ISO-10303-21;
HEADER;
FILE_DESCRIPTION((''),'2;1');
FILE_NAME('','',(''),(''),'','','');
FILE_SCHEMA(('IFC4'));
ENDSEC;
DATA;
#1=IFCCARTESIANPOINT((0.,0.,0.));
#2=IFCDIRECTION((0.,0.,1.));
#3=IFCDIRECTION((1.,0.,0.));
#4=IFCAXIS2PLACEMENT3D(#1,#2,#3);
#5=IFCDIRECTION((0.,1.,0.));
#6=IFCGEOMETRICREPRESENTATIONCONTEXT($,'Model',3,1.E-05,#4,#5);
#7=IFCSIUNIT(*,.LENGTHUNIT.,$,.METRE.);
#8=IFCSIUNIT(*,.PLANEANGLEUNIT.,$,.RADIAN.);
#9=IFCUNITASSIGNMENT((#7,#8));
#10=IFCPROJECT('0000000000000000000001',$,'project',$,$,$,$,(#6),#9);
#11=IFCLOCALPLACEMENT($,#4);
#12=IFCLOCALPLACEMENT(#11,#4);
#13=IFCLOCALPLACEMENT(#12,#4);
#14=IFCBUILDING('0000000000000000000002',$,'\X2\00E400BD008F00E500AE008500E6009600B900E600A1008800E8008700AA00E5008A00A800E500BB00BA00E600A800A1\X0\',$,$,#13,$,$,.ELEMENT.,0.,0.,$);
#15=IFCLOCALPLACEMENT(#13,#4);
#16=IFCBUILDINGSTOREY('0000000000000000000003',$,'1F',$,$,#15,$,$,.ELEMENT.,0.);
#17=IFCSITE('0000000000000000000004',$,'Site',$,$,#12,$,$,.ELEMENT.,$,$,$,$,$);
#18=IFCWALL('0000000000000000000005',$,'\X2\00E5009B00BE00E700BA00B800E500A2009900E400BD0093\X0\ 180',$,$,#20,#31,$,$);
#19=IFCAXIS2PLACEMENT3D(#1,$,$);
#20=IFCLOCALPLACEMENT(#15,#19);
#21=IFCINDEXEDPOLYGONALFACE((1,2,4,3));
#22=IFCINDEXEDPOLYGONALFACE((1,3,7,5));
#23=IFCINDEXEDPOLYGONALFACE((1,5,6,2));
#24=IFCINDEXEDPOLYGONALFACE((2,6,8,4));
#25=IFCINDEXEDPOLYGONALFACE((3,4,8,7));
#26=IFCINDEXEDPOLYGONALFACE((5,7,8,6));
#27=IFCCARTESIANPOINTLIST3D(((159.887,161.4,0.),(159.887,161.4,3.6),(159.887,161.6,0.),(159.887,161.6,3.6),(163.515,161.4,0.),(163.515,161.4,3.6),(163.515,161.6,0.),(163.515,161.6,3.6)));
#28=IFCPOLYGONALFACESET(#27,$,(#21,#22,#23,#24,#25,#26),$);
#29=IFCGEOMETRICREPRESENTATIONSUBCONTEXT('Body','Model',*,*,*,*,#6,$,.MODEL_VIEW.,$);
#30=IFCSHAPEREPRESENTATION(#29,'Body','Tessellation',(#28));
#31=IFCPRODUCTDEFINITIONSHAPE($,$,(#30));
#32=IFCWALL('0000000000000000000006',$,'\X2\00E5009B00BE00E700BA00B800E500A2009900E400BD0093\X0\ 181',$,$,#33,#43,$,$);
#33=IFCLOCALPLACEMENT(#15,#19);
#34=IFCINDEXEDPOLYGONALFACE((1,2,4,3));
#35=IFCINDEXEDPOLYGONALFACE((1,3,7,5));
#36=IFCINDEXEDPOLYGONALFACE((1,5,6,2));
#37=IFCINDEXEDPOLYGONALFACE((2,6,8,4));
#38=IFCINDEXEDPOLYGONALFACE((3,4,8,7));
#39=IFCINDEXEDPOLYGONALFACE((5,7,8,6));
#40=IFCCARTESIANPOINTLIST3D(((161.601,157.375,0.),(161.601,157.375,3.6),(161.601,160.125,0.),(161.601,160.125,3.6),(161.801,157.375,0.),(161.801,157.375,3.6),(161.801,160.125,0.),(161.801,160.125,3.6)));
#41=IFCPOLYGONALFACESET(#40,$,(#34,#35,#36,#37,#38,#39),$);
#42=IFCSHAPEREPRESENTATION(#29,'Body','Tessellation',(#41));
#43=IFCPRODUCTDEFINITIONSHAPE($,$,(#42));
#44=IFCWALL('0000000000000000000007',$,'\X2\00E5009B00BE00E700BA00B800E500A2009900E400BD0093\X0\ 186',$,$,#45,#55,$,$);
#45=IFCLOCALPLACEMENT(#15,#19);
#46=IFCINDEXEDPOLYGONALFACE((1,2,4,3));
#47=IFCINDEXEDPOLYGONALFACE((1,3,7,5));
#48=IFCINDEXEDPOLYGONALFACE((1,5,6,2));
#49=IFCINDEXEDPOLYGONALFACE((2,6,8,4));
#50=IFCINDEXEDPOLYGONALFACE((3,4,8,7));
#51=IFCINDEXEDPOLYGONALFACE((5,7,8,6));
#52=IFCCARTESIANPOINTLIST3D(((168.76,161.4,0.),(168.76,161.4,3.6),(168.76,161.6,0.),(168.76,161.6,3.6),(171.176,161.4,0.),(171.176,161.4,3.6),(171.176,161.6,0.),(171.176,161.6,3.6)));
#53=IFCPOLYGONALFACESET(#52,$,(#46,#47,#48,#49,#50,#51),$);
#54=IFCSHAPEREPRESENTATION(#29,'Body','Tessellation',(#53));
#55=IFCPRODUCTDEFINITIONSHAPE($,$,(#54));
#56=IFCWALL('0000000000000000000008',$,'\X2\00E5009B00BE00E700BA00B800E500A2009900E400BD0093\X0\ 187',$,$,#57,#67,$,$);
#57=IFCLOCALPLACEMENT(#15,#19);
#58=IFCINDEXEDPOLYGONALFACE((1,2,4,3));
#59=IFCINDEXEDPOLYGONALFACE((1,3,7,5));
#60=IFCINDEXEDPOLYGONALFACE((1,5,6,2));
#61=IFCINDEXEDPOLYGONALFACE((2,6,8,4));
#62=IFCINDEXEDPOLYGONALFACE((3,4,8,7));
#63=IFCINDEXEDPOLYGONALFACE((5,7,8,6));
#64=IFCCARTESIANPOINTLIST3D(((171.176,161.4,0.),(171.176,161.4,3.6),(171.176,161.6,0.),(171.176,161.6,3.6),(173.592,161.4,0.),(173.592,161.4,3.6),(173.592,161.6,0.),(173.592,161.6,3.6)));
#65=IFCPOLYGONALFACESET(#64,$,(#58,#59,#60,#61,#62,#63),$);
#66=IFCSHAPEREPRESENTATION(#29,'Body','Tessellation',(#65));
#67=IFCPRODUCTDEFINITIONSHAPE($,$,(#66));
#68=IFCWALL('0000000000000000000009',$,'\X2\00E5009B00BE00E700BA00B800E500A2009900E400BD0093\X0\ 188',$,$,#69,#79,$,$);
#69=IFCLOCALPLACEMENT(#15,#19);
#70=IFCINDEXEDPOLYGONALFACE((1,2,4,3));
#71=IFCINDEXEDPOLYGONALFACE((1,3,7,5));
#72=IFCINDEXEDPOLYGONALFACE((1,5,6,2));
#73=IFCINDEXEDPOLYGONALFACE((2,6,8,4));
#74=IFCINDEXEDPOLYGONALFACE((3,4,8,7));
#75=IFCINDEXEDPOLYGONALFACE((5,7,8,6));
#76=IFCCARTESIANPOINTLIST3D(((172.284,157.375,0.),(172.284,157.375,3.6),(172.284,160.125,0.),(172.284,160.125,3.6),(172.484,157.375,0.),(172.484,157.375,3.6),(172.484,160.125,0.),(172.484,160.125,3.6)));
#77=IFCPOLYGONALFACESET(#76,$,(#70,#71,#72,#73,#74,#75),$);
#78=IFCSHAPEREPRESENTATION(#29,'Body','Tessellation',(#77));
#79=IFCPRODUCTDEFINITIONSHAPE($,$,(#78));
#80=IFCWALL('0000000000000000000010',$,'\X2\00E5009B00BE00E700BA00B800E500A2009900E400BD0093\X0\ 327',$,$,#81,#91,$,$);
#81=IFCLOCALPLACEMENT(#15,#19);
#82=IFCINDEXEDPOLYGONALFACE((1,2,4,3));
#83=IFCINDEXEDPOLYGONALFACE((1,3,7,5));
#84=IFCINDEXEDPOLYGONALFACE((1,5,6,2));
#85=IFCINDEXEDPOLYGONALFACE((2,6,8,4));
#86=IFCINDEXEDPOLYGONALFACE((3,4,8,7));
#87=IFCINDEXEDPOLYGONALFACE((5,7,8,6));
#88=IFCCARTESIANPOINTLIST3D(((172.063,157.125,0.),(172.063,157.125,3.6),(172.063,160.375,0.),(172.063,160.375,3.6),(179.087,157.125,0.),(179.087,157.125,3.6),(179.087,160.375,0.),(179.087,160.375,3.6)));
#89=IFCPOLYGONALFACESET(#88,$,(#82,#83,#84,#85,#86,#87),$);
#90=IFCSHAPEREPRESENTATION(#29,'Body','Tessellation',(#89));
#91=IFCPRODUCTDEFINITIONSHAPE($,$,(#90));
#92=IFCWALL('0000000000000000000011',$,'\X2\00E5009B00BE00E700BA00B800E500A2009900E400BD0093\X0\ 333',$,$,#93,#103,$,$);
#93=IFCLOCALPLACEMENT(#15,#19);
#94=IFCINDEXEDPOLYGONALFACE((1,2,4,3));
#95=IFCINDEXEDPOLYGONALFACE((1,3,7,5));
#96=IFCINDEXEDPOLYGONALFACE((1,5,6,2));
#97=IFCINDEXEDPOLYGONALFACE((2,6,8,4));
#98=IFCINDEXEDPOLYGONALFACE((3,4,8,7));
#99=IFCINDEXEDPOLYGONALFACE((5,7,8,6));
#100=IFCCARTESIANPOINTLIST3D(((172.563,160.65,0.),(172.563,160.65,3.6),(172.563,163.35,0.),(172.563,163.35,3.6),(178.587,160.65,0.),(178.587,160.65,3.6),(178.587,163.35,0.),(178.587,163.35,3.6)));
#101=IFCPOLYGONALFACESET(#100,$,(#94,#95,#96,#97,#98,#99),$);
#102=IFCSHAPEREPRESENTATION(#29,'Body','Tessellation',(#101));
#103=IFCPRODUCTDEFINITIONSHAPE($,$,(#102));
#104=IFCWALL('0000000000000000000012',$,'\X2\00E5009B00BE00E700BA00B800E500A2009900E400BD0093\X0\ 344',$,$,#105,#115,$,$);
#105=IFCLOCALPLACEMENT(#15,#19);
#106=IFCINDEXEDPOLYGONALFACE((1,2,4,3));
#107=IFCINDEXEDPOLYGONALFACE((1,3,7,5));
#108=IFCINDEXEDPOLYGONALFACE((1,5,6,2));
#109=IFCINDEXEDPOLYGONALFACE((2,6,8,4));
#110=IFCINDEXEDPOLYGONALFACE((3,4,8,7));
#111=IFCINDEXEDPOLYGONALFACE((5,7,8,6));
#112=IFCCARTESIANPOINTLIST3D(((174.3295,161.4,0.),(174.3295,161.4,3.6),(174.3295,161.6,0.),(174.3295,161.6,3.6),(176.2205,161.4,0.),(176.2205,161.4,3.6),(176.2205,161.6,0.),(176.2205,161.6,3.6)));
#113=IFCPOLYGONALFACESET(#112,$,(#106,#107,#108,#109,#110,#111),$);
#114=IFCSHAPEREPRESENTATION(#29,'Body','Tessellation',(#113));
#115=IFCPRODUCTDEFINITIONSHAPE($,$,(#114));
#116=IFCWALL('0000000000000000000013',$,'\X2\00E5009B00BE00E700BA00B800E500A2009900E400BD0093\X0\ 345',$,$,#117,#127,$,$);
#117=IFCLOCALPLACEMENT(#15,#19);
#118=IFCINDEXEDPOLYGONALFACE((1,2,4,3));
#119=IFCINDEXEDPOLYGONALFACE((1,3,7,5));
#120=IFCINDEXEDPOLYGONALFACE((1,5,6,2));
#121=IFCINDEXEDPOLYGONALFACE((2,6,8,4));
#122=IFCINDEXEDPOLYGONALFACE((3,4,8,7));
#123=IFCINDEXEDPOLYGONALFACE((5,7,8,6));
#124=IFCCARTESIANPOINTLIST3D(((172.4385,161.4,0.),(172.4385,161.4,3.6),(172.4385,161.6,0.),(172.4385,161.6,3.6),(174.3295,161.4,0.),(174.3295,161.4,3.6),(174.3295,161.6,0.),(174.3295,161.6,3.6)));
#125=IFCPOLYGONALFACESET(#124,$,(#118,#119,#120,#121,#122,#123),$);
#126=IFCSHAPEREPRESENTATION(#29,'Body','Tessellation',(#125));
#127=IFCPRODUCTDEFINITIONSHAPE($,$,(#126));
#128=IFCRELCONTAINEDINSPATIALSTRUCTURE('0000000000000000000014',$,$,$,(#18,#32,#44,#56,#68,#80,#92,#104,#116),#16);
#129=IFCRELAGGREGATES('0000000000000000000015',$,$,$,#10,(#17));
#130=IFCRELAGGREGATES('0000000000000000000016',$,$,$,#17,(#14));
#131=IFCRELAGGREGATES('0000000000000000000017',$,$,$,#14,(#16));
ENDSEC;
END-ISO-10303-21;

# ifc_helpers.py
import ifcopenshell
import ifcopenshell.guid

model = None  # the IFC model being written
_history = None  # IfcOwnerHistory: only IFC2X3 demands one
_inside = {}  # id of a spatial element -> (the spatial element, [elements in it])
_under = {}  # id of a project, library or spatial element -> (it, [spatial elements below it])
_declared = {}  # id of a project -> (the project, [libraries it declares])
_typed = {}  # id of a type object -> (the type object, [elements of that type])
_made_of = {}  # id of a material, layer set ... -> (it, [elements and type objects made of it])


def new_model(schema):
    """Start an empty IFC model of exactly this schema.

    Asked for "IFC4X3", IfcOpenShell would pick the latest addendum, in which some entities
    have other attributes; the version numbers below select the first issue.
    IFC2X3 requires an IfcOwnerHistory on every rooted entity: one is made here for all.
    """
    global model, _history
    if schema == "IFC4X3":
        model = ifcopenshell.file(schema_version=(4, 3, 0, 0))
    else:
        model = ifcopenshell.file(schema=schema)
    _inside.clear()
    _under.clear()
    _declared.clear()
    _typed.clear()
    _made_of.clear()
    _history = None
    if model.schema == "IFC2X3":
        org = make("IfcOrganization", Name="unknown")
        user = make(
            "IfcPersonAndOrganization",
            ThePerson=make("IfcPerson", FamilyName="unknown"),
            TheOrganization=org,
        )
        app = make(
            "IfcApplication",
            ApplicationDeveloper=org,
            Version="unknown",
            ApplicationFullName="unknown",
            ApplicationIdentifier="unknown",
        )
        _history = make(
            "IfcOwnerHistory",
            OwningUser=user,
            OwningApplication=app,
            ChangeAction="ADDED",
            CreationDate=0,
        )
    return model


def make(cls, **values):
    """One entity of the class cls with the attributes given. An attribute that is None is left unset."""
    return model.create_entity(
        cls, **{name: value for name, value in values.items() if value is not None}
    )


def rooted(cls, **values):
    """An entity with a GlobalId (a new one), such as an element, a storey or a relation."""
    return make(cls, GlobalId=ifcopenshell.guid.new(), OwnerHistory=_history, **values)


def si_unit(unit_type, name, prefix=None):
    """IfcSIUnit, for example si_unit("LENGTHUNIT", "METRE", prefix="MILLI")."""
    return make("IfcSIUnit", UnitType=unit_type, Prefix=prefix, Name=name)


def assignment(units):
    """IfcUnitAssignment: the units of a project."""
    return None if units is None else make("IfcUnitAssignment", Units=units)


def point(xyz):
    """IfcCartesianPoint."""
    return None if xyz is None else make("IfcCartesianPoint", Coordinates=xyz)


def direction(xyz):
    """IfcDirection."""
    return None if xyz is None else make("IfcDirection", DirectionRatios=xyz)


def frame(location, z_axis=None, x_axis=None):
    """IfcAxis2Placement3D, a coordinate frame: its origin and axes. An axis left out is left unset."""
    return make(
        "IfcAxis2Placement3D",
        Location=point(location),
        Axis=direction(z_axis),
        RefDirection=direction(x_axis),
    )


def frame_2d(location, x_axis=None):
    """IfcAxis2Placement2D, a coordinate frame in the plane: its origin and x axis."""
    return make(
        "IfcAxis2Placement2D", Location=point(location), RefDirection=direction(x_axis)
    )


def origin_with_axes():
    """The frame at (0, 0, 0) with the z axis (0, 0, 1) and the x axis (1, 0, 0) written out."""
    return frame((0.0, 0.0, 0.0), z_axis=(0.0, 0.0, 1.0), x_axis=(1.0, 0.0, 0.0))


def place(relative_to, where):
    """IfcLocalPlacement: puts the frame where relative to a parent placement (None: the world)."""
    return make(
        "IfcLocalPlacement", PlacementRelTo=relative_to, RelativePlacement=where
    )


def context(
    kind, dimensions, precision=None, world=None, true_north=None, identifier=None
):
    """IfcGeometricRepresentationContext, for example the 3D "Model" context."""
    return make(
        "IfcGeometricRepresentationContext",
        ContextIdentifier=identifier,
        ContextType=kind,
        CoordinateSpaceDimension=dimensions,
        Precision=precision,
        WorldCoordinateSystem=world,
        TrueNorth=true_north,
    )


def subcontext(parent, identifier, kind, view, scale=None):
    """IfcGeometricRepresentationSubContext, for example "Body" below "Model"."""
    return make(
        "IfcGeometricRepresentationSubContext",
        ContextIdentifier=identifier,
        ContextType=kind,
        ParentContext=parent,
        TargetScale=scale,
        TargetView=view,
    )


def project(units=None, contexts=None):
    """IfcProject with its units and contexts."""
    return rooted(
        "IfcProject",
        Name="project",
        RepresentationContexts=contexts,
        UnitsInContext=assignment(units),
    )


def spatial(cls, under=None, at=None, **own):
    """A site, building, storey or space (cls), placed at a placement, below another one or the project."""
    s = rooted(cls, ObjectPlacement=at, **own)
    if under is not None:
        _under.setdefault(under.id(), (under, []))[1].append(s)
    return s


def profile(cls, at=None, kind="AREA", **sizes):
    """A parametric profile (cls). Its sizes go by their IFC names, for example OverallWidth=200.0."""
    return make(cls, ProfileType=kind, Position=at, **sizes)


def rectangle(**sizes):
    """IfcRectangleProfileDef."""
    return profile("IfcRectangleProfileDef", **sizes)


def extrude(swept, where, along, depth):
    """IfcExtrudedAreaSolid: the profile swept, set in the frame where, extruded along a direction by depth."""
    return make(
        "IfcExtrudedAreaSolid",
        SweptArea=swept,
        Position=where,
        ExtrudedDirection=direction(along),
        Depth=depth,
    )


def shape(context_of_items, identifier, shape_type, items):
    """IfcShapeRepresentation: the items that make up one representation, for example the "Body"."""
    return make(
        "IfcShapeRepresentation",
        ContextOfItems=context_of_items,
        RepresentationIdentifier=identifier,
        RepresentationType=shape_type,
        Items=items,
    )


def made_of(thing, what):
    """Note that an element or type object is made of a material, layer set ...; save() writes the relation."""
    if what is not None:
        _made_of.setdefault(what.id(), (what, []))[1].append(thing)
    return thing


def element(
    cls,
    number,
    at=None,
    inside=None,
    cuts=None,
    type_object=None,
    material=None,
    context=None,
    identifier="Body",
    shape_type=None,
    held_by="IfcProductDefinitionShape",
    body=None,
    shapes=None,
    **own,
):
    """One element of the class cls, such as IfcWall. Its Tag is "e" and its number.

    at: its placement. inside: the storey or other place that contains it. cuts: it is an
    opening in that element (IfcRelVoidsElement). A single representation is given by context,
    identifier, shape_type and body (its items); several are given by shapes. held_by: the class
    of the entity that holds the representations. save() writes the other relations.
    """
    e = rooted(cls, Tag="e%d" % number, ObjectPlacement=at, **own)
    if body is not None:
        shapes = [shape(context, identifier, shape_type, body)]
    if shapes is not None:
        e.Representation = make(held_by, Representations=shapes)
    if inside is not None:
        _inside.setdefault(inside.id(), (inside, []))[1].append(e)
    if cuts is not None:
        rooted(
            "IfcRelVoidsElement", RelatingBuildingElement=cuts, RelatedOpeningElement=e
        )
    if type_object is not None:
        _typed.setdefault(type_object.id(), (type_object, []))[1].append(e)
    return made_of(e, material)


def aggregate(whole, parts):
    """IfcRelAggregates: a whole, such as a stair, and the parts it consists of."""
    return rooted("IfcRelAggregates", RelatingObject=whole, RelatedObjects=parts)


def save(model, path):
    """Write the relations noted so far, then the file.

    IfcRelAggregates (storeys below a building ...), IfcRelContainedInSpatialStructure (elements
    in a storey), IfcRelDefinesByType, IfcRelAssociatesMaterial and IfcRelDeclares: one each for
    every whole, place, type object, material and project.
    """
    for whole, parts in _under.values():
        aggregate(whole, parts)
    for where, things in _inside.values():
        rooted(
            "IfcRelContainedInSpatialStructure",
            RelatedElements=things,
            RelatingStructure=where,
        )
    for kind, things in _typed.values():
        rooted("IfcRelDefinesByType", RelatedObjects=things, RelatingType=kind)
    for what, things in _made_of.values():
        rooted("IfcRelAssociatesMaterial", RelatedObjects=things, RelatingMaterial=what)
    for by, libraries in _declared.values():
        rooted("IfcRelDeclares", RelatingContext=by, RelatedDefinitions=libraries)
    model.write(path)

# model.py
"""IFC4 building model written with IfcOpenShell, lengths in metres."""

from ifc_helpers import new_model, si_unit, direction, frame, frame_2d, origin_with_axes, place, context, subcontext, project, spatial, rectangle, extrude, element, save


model = new_model("IFC4")

# Units and contexts
model_context = context("Model", 3, precision=1e-05, world=origin_with_axes(), true_north=direction((0.0, 1.0, 0.0)))
body_context = subcontext(model_context, "Body", "Model", "MODEL_VIEW")
ifc_project = project(units=[si_unit("LENGTHUNIT", "METRE"), si_unit("PLANEANGLEUNIT", "RADIAN")], contexts=[model_context])

# Site, building, storey
placement = place(None, origin_with_axes())
site_placement = place(placement, origin_with_axes())
site = spatial("IfcSite", under=ifc_project, at=site_placement, Name="Site", CompositionType="ELEMENT")
building_placement = place(site_placement, origin_with_axes())
building = spatial("IfcBuilding", under=site, at=building_placement, Name="ä½\u008få®\u0085æ\u0096¹æ¡\u0088è\u0087ªå\u008a¨å»ºæ¨¡", CompositionType="ELEMENT", ElevationOfRefHeight=0.0, ElevationOfTerrain=0.0)
storey_placement = place(building_placement, origin_with_axes())
storey = spatial("IfcBuildingStorey", under=building, at=storey_placement, Name="1F", CompositionType="ELEMENT", Elevation=0.0)

# Walls
wall_1_placement = place(storey_placement, frame((161.701, 161.5, 0.0), z_axis=(0.0, 0.0, 1.0), x_axis=(1.0, 0.0, 0.0)))
element("IfcWall", 1, at=wall_1_placement, inside=storey, Name="å\u009b¾çº¸å¢\u0099ä½\u0093 180", context=body_context, shape_type="SweptSolid", body=[
    extrude(rectangle(XDim=3.628, YDim=0.2, at=frame_2d((0.0, 0.0), x_axis=(1.0, 0.0, 0.0))), frame((0.0, 0.0, 0.0), z_axis=(0.0, 0.0, 1.0)), (0.0, 0.0, 1.0), 3.6),
])
wall_2_placement = place(storey_placement, frame((161.701, 158.75, 0.0), z_axis=(0.0, 0.0, 1.0), x_axis=(0.0, 1.0, 0.0)))
element("IfcWall", 2, at=wall_2_placement, inside=storey, Name="å\u009b¾çº¸å¢\u0099ä½\u0093 181", context=body_context, shape_type="SweptSolid", body=[
    extrude(rectangle(XDim=2.75, YDim=0.2, at=frame_2d((0.0, 0.0), x_axis=(1.0, 0.0, 0.0))), frame((0.0, 0.0, 0.0), z_axis=(0.0, 0.0, 1.0)), (0.0, 0.0, 1.0), 3.6),
])
for number, where, z_axis, x_axis, name in (
    (3, (169.968, 161.5, 0.0), (0.0, 0.0, 1.0), (1.0, 0.0, 0.0), "å\u009b¾çº¸å¢\u0099ä½\u0093 186"),
    (4, (172.384, 161.5, 0.0), (0.0, 0.0, 1.0), (-1.0, 0.0, 0.0), "å\u009b¾çº¸å¢\u0099ä½\u0093 187"),
):
    element("IfcWall", number, at=place(storey_placement, frame(where, z_axis=z_axis, x_axis=x_axis)), inside=storey, Name=name, context=body_context, shape_type="SweptSolid", body=[
        extrude(rectangle(XDim=2.416, YDim=0.2, at=frame_2d((0.0, 0.0), x_axis=(1.0, 0.0, 0.0))), frame((0.0, 0.0, 0.0), z_axis=(0.0, 0.0, 1.0)), (0.0, 0.0, 1.0), 3.6),
    ])
wall_3_placement = place(storey_placement, frame((172.384, 158.75, 0.0), z_axis=(0.0, 0.0, 1.0), x_axis=(0.0, 1.0, 0.0)))
element("IfcWall", 5, at=wall_3_placement, inside=storey, Name="å\u009b¾çº¸å¢\u0099ä½\u0093 188", context=body_context, shape_type="SweptSolid", body=[
    extrude(rectangle(XDim=2.75, YDim=0.2, at=frame_2d((0.0, 0.0), x_axis=(1.0, 0.0, 0.0))), frame((0.0, 0.0, 0.0), z_axis=(0.0, 0.0, 1.0)), (0.0, 0.0, 1.0), 3.6),
])
wall_4_placement = place(storey_placement, frame((175.575, 158.75, 0.0), z_axis=(0.0, 0.0, 1.0), x_axis=(1.0, 0.0, 0.0)))
element("IfcWall", 6, at=wall_4_placement, inside=storey, Name="å\u009b¾çº¸å¢\u0099ä½\u0093 327", context=body_context, shape_type="SweptSolid", body=[
    extrude(rectangle(XDim=7.024, YDim=3.25, at=frame_2d((0.0, 0.0), x_axis=(1.0, 0.0, 0.0))), frame((0.0, 0.0, 0.0), z_axis=(0.0, 0.0, 1.0)), (0.0, 0.0, 1.0), 3.6),
])
wall_5_placement = place(storey_placement, frame((175.575, 162.0, 0.0), z_axis=(0.0, 0.0, 1.0), x_axis=(1.0, 0.0, 0.0)))
element("IfcWall", 7, at=wall_5_placement, inside=storey, Name="å\u009b¾çº¸å¢\u0099ä½\u0093 333", context=body_context, shape_type="SweptSolid", body=[
    extrude(rectangle(XDim=6.024, YDim=2.7, at=frame_2d((0.0, 0.0), x_axis=(1.0, 0.0, 0.0))), frame((0.0, 0.0, 0.0), z_axis=(0.0, 0.0, 1.0)), (0.0, 0.0, 1.0), 3.6),
])
for number, where, z_axis, x_axis, name in (
    (8, (175.275, 161.5, 0.0), (0.0, 0.0, 1.0), (-1.0, 0.0, 0.0), "å\u009b¾çº¸å¢\u0099ä½\u0093 344"),
    (9, (173.384, 161.5, 0.0), (0.0, 0.0, 1.0), (1.0, 0.0, 0.0), "å\u009b¾çº¸å¢\u0099ä½\u0093 345"),
):
    element("IfcWall", number, at=place(storey_placement, frame(where, z_axis=z_axis, x_axis=x_axis)), inside=storey, Name=name, context=body_context, shape_type="SweptSolid", body=[
        extrude(rectangle(XDim=1.891, YDim=0.2, at=frame_2d((0.0, 0.0), x_axis=(1.0, 0.0, 0.0))), frame((0.0, 0.0, 0.0), z_axis=(0.0, 0.0, 1.0)), (0.0, 0.0, 1.0), 3.6),
    ])

save(model, "model.ifc")
